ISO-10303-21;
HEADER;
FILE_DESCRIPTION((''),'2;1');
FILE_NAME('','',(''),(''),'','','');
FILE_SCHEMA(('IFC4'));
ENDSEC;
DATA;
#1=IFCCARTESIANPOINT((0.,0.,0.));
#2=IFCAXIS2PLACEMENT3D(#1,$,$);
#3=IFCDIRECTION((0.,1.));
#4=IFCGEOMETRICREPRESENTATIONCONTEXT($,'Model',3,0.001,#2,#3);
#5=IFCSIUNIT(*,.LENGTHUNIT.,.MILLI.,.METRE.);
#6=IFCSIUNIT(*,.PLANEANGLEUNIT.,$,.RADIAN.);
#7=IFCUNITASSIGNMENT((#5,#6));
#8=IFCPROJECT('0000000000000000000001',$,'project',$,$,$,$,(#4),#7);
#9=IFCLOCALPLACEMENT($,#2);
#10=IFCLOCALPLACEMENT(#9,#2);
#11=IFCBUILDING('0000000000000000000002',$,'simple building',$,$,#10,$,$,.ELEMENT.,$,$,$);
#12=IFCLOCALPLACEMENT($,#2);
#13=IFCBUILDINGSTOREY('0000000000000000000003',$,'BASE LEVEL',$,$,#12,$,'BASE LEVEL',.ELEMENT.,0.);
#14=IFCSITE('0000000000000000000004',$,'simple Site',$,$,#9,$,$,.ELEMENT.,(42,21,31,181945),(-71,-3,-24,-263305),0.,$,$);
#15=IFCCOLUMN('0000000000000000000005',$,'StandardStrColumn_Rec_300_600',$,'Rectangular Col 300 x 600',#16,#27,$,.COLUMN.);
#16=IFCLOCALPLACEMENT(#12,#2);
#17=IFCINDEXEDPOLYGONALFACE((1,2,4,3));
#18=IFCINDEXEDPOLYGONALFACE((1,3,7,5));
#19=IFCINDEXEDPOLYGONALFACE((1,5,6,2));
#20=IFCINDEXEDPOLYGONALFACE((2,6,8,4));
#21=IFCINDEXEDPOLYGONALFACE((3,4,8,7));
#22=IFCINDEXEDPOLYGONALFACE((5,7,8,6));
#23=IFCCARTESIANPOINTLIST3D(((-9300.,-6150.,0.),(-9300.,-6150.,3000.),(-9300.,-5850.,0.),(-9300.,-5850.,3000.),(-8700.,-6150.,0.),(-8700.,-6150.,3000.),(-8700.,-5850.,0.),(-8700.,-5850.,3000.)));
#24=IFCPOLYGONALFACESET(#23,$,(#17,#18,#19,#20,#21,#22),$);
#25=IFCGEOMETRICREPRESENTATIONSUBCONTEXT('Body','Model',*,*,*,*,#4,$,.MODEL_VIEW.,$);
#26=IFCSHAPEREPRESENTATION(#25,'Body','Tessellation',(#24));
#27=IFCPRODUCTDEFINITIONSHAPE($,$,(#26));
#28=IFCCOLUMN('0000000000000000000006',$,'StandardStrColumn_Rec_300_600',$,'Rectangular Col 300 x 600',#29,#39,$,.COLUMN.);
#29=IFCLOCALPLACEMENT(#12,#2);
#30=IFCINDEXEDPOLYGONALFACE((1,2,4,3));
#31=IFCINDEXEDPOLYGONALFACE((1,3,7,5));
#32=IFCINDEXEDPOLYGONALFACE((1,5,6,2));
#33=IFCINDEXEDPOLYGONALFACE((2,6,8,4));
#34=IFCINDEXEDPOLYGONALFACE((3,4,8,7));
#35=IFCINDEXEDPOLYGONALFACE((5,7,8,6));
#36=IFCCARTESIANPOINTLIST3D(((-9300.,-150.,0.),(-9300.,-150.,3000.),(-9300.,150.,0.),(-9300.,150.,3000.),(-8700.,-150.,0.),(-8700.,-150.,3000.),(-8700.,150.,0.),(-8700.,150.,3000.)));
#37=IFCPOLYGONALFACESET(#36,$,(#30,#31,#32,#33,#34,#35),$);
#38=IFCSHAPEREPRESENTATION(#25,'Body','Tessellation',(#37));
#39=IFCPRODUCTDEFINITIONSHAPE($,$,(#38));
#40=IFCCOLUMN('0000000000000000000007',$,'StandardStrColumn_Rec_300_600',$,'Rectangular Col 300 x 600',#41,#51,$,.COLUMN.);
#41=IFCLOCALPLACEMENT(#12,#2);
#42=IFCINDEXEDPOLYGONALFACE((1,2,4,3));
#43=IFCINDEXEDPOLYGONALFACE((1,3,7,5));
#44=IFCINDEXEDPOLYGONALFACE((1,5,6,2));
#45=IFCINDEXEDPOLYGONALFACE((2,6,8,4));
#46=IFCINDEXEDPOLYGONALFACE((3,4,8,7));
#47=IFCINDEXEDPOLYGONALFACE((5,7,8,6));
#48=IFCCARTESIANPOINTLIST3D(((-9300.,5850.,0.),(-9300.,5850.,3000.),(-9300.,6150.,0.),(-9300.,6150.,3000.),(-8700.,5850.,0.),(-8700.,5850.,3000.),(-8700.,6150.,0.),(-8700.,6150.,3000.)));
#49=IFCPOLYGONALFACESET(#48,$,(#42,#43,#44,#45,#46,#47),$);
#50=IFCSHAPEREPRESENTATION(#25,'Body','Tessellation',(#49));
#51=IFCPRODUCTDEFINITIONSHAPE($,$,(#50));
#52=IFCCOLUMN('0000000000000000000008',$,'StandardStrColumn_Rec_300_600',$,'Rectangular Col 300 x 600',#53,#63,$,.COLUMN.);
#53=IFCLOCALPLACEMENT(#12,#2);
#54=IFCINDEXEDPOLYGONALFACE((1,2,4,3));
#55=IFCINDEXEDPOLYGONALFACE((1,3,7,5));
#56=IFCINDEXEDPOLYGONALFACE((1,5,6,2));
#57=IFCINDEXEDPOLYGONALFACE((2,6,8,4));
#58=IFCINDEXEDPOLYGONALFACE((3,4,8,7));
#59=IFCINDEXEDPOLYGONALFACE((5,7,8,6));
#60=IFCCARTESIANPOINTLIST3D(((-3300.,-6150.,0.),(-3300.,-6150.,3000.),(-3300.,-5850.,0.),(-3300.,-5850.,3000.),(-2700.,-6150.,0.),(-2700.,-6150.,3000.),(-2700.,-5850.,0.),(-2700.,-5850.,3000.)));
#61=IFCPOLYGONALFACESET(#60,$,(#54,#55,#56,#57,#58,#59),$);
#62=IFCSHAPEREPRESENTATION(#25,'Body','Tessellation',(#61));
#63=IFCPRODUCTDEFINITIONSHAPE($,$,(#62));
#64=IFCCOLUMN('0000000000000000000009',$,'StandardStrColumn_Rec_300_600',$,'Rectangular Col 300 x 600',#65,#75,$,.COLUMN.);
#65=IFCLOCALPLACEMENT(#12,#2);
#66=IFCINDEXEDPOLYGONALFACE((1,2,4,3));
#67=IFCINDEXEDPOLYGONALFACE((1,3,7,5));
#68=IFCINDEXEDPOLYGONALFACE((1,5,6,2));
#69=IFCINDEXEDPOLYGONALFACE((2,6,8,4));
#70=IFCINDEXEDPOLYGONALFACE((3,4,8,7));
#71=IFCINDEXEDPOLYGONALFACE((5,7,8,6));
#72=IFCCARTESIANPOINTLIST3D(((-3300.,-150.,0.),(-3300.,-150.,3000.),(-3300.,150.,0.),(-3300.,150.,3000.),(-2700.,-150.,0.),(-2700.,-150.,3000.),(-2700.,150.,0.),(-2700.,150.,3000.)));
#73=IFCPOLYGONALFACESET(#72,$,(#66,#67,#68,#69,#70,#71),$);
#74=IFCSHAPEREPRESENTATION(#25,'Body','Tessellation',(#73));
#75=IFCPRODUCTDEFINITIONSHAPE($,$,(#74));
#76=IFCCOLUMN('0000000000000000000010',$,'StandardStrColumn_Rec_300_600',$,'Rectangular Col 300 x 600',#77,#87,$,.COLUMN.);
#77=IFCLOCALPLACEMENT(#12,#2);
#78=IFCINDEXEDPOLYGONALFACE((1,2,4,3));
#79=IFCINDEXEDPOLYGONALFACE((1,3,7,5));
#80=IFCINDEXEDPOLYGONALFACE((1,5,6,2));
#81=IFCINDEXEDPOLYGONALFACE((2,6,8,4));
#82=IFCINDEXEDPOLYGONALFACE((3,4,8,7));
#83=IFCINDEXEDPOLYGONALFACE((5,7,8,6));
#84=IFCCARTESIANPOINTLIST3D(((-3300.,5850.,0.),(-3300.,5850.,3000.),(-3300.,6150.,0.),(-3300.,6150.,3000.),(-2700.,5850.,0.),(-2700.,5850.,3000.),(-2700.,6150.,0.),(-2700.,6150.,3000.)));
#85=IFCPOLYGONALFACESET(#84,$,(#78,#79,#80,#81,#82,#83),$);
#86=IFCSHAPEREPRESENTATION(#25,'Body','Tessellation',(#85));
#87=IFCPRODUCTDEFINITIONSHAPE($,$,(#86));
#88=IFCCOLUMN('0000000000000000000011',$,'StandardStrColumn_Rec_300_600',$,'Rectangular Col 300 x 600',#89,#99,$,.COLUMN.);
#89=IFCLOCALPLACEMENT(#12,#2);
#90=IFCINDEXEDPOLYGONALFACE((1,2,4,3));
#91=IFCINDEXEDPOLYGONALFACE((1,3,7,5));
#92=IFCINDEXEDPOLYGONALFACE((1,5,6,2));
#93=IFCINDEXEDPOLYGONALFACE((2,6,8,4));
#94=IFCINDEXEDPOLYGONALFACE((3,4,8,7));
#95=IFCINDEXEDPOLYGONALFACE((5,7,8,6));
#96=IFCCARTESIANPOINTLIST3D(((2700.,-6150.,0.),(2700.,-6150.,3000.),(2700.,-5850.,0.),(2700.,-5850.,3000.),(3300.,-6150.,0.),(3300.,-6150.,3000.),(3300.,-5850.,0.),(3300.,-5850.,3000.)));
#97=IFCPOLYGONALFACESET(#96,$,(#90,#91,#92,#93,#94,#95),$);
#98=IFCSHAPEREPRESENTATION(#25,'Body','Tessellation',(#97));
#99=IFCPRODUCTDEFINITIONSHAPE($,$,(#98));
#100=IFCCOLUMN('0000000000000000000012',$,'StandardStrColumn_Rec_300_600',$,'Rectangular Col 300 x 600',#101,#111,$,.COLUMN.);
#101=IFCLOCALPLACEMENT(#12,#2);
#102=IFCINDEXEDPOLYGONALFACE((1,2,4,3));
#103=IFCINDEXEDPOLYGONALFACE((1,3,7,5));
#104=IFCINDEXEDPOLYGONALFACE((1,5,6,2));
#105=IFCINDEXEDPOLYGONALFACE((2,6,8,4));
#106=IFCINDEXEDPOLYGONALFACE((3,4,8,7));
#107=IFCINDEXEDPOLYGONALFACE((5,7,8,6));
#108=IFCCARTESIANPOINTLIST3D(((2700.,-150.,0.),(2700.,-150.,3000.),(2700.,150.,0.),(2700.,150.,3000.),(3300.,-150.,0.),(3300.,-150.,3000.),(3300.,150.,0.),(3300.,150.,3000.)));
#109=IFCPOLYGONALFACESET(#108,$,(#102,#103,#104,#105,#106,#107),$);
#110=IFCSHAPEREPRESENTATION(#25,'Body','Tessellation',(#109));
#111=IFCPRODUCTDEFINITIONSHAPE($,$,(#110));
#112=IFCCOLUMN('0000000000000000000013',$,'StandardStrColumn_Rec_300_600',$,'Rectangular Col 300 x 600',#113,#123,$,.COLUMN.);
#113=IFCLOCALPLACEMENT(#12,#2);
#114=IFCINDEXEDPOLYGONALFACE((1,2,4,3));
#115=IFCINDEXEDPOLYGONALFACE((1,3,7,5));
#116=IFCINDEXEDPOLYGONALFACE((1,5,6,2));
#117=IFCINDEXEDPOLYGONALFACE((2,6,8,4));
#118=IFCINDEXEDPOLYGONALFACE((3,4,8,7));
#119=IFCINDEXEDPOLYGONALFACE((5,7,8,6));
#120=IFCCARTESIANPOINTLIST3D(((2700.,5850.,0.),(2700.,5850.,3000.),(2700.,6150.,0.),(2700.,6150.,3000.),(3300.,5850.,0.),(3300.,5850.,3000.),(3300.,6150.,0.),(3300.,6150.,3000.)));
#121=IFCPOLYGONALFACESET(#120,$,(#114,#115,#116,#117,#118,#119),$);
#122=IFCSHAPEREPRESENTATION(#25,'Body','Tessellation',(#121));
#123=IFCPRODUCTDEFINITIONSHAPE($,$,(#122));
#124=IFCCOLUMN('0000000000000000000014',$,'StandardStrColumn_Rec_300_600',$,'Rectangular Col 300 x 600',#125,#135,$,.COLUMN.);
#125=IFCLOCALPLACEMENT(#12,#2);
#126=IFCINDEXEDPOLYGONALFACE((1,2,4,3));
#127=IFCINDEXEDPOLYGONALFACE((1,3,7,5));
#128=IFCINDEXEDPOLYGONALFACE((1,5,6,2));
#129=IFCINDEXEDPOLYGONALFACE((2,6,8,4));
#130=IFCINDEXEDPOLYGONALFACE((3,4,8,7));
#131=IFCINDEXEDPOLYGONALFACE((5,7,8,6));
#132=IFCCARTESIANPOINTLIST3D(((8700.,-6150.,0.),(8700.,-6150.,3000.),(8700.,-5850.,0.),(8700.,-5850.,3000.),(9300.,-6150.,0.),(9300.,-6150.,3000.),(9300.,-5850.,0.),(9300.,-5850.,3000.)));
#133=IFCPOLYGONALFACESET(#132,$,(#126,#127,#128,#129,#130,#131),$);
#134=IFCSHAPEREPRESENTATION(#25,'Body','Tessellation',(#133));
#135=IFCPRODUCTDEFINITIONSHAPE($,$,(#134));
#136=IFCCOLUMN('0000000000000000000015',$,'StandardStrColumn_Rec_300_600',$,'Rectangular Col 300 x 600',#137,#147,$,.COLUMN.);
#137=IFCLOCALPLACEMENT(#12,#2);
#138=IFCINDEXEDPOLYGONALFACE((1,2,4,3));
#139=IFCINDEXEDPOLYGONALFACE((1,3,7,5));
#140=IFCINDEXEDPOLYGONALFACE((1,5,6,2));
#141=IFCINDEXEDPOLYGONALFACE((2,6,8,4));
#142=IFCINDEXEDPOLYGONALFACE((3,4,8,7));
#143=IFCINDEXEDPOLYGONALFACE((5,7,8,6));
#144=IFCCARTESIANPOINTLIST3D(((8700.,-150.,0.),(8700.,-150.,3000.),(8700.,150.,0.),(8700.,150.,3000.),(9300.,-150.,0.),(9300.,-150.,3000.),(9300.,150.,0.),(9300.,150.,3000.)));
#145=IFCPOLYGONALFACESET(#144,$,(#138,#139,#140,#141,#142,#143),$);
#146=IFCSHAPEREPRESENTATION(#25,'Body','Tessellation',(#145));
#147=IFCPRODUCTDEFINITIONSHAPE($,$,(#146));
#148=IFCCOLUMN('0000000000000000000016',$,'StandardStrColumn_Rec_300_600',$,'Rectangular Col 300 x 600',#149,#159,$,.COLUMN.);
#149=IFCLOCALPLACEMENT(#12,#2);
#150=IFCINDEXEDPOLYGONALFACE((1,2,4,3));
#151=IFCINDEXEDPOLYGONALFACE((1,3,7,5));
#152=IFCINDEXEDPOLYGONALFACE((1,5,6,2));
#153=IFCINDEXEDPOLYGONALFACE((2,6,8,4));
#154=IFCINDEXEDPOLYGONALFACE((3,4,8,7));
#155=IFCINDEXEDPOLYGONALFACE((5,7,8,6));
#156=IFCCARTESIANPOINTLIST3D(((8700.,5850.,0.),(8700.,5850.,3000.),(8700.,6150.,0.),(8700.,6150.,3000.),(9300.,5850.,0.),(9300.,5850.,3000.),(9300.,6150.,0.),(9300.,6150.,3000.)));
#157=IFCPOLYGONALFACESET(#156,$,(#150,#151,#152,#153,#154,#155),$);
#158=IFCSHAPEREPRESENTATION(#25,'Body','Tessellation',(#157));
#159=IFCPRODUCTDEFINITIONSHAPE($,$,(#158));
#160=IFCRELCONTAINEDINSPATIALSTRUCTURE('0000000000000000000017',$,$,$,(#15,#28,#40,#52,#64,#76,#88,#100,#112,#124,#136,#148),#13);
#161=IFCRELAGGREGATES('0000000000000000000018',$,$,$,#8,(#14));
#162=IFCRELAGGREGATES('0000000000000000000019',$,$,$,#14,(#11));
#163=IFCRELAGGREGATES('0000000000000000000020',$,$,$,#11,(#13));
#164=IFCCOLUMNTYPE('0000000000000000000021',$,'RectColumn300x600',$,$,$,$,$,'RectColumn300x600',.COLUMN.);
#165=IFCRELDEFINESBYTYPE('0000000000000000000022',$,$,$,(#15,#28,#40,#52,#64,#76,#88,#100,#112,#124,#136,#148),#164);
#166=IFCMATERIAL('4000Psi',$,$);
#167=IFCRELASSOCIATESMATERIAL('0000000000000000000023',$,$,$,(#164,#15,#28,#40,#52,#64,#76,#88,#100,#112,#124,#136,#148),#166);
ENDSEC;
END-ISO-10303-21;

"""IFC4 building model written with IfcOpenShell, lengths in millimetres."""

from ifc_helpers import new_model, si_unit, direction, frame, origin, origin_with_axes, origin_2d_with_axis, place, context, subcontext, project, spatial, rectangle, extrude, material, material_profile, profile_set, profile_usage, type_object, element, save


model = new_model("IFC4")

# Units and contexts
model_context = context("Model", 3, precision=0.001, world=origin(), true_north=direction((0.0, 1.0)))
body_context = subcontext(model_context, "Body", "Model", "MODEL_VIEW")
ifc_project = project(units=[si_unit("LENGTHUNIT", "METRE", prefix="MILLI"), si_unit("PLANEANGLEUNIT", "RADIAN")], contexts=[model_context])

# Site, building, storey
site_placement = place(None, origin())
site = spatial("IfcSite", under=ifc_project, at=site_placement, Name="simple Site", CompositionType="ELEMENT", RefLatitude=(42, 21, 31, 181945), RefLongitude=(-71, -3, -24, -263305), RefElevation=0.0)
building_placement = place(site_placement, origin())
building = spatial("IfcBuilding", under=site, at=building_placement, Name="simple building", CompositionType="ELEMENT")
storey_placement = place(None, origin())
storey = spatial("IfcBuildingStorey", under=building, at=storey_placement, Name="BASE LEVEL", LongName="BASE LEVEL", CompositionType="ELEMENT", Elevation=0.0)

# Columns
ifc_material = material(Name="4000Psi")
ifc_material_profile = material_profile(ifc_material, rectangle(XDim=300.0, YDim=600.0, at=origin_2d_with_axis()))
ifc_profile_set = profile_set([ifc_material_profile])
ifc_profile_usage = profile_usage(ifc_profile_set, cardinal=10)
column_type = type_object("IfcColumnType", Name="RectColumn300x600", ElementType="RectColumn300x600", PredefinedType="COLUMN", material=ifc_profile_usage)
for number, where, z_axis, x_axis, name in (
    (1, (-9000.0, -6000.0, 0.0), (0.0, 0.0, 1.0), (0.0, 1.0, 0.0), "StandardStrColumn_Rec_300_600"),
    (2, (-9000.0, 0.0, 0.0), (0.0, 0.0, 1.0), (0.0, 1.0, 0.0), "StandardStrColumn_Rec_300_600"),
    (3, (-9000.0, 6000.0, 0.0), (0.0, 0.0, 1.0), (0.0, 1.0, 0.0), "StandardStrColumn_Rec_300_600"),
    (4, (-3000.0, -6000.0, 0.0), (0.0, 0.0, 1.0), (0.0, 1.0, 0.0), "StandardStrColumn_Rec_300_600"),
    (5, (-3000.0, 0.0, 0.0), (0.0, 0.0, 1.0), (0.0, 1.0, 0.0), "StandardStrColumn_Rec_300_600"),
    (6, (-3000.0, 6000.0, 0.0), (0.0, 0.0, 1.0), (0.0, 1.0, 0.0), "StandardStrColumn_Rec_300_600"),
    (7, (3000.0, -6000.0, 0.0), (0.0, 0.0, 1.0), (0.0, 1.0, 0.0), "StandardStrColumn_Rec_300_600"),
    (8, (3000.0, 0.0, 0.0), (0.0, 0.0, 1.0), (0.0, 1.0, 0.0), "StandardStrColumn_Rec_300_600"),
    (9, (3000.0, 6000.0, 0.0), (0.0, 0.0, 1.0), (0.0, 1.0, 0.0), "StandardStrColumn_Rec_300_600"),
    (10, (9000.0, -6000.0, 0.0), (0.0, 0.0, 1.0), (0.0, 1.0, 0.0), "StandardStrColumn_Rec_300_600"),
    (11, (9000.0, 0.0, 0.0), (0.0, 0.0, 1.0), (0.0, 1.0, 0.0), "StandardStrColumn_Rec_300_600"),
    (12, (9000.0, 6000.0, 0.0), (0.0, 0.0, 1.0), (0.0, 1.0, 0.0), "StandardStrColumn_Rec_300_600"),
):
    element("IfcColumn", number, at=place(None, frame(where, z_axis=z_axis, x_axis=x_axis)), inside=storey, type_object=column_type, material=ifc_profile_usage, Name=name, ObjectType="Rectangular Col 300 x 600", PredefinedType="COLUMN", context=body_context, shape_type="SweptSolid", body=[
        extrude(rectangle(XDim=300.0, YDim=600.0, at=origin_2d_with_axis()), origin_with_axes(), (0.0, 0.0, 1.0), 3000.0),
    ])

save(model, "model.ifc")
